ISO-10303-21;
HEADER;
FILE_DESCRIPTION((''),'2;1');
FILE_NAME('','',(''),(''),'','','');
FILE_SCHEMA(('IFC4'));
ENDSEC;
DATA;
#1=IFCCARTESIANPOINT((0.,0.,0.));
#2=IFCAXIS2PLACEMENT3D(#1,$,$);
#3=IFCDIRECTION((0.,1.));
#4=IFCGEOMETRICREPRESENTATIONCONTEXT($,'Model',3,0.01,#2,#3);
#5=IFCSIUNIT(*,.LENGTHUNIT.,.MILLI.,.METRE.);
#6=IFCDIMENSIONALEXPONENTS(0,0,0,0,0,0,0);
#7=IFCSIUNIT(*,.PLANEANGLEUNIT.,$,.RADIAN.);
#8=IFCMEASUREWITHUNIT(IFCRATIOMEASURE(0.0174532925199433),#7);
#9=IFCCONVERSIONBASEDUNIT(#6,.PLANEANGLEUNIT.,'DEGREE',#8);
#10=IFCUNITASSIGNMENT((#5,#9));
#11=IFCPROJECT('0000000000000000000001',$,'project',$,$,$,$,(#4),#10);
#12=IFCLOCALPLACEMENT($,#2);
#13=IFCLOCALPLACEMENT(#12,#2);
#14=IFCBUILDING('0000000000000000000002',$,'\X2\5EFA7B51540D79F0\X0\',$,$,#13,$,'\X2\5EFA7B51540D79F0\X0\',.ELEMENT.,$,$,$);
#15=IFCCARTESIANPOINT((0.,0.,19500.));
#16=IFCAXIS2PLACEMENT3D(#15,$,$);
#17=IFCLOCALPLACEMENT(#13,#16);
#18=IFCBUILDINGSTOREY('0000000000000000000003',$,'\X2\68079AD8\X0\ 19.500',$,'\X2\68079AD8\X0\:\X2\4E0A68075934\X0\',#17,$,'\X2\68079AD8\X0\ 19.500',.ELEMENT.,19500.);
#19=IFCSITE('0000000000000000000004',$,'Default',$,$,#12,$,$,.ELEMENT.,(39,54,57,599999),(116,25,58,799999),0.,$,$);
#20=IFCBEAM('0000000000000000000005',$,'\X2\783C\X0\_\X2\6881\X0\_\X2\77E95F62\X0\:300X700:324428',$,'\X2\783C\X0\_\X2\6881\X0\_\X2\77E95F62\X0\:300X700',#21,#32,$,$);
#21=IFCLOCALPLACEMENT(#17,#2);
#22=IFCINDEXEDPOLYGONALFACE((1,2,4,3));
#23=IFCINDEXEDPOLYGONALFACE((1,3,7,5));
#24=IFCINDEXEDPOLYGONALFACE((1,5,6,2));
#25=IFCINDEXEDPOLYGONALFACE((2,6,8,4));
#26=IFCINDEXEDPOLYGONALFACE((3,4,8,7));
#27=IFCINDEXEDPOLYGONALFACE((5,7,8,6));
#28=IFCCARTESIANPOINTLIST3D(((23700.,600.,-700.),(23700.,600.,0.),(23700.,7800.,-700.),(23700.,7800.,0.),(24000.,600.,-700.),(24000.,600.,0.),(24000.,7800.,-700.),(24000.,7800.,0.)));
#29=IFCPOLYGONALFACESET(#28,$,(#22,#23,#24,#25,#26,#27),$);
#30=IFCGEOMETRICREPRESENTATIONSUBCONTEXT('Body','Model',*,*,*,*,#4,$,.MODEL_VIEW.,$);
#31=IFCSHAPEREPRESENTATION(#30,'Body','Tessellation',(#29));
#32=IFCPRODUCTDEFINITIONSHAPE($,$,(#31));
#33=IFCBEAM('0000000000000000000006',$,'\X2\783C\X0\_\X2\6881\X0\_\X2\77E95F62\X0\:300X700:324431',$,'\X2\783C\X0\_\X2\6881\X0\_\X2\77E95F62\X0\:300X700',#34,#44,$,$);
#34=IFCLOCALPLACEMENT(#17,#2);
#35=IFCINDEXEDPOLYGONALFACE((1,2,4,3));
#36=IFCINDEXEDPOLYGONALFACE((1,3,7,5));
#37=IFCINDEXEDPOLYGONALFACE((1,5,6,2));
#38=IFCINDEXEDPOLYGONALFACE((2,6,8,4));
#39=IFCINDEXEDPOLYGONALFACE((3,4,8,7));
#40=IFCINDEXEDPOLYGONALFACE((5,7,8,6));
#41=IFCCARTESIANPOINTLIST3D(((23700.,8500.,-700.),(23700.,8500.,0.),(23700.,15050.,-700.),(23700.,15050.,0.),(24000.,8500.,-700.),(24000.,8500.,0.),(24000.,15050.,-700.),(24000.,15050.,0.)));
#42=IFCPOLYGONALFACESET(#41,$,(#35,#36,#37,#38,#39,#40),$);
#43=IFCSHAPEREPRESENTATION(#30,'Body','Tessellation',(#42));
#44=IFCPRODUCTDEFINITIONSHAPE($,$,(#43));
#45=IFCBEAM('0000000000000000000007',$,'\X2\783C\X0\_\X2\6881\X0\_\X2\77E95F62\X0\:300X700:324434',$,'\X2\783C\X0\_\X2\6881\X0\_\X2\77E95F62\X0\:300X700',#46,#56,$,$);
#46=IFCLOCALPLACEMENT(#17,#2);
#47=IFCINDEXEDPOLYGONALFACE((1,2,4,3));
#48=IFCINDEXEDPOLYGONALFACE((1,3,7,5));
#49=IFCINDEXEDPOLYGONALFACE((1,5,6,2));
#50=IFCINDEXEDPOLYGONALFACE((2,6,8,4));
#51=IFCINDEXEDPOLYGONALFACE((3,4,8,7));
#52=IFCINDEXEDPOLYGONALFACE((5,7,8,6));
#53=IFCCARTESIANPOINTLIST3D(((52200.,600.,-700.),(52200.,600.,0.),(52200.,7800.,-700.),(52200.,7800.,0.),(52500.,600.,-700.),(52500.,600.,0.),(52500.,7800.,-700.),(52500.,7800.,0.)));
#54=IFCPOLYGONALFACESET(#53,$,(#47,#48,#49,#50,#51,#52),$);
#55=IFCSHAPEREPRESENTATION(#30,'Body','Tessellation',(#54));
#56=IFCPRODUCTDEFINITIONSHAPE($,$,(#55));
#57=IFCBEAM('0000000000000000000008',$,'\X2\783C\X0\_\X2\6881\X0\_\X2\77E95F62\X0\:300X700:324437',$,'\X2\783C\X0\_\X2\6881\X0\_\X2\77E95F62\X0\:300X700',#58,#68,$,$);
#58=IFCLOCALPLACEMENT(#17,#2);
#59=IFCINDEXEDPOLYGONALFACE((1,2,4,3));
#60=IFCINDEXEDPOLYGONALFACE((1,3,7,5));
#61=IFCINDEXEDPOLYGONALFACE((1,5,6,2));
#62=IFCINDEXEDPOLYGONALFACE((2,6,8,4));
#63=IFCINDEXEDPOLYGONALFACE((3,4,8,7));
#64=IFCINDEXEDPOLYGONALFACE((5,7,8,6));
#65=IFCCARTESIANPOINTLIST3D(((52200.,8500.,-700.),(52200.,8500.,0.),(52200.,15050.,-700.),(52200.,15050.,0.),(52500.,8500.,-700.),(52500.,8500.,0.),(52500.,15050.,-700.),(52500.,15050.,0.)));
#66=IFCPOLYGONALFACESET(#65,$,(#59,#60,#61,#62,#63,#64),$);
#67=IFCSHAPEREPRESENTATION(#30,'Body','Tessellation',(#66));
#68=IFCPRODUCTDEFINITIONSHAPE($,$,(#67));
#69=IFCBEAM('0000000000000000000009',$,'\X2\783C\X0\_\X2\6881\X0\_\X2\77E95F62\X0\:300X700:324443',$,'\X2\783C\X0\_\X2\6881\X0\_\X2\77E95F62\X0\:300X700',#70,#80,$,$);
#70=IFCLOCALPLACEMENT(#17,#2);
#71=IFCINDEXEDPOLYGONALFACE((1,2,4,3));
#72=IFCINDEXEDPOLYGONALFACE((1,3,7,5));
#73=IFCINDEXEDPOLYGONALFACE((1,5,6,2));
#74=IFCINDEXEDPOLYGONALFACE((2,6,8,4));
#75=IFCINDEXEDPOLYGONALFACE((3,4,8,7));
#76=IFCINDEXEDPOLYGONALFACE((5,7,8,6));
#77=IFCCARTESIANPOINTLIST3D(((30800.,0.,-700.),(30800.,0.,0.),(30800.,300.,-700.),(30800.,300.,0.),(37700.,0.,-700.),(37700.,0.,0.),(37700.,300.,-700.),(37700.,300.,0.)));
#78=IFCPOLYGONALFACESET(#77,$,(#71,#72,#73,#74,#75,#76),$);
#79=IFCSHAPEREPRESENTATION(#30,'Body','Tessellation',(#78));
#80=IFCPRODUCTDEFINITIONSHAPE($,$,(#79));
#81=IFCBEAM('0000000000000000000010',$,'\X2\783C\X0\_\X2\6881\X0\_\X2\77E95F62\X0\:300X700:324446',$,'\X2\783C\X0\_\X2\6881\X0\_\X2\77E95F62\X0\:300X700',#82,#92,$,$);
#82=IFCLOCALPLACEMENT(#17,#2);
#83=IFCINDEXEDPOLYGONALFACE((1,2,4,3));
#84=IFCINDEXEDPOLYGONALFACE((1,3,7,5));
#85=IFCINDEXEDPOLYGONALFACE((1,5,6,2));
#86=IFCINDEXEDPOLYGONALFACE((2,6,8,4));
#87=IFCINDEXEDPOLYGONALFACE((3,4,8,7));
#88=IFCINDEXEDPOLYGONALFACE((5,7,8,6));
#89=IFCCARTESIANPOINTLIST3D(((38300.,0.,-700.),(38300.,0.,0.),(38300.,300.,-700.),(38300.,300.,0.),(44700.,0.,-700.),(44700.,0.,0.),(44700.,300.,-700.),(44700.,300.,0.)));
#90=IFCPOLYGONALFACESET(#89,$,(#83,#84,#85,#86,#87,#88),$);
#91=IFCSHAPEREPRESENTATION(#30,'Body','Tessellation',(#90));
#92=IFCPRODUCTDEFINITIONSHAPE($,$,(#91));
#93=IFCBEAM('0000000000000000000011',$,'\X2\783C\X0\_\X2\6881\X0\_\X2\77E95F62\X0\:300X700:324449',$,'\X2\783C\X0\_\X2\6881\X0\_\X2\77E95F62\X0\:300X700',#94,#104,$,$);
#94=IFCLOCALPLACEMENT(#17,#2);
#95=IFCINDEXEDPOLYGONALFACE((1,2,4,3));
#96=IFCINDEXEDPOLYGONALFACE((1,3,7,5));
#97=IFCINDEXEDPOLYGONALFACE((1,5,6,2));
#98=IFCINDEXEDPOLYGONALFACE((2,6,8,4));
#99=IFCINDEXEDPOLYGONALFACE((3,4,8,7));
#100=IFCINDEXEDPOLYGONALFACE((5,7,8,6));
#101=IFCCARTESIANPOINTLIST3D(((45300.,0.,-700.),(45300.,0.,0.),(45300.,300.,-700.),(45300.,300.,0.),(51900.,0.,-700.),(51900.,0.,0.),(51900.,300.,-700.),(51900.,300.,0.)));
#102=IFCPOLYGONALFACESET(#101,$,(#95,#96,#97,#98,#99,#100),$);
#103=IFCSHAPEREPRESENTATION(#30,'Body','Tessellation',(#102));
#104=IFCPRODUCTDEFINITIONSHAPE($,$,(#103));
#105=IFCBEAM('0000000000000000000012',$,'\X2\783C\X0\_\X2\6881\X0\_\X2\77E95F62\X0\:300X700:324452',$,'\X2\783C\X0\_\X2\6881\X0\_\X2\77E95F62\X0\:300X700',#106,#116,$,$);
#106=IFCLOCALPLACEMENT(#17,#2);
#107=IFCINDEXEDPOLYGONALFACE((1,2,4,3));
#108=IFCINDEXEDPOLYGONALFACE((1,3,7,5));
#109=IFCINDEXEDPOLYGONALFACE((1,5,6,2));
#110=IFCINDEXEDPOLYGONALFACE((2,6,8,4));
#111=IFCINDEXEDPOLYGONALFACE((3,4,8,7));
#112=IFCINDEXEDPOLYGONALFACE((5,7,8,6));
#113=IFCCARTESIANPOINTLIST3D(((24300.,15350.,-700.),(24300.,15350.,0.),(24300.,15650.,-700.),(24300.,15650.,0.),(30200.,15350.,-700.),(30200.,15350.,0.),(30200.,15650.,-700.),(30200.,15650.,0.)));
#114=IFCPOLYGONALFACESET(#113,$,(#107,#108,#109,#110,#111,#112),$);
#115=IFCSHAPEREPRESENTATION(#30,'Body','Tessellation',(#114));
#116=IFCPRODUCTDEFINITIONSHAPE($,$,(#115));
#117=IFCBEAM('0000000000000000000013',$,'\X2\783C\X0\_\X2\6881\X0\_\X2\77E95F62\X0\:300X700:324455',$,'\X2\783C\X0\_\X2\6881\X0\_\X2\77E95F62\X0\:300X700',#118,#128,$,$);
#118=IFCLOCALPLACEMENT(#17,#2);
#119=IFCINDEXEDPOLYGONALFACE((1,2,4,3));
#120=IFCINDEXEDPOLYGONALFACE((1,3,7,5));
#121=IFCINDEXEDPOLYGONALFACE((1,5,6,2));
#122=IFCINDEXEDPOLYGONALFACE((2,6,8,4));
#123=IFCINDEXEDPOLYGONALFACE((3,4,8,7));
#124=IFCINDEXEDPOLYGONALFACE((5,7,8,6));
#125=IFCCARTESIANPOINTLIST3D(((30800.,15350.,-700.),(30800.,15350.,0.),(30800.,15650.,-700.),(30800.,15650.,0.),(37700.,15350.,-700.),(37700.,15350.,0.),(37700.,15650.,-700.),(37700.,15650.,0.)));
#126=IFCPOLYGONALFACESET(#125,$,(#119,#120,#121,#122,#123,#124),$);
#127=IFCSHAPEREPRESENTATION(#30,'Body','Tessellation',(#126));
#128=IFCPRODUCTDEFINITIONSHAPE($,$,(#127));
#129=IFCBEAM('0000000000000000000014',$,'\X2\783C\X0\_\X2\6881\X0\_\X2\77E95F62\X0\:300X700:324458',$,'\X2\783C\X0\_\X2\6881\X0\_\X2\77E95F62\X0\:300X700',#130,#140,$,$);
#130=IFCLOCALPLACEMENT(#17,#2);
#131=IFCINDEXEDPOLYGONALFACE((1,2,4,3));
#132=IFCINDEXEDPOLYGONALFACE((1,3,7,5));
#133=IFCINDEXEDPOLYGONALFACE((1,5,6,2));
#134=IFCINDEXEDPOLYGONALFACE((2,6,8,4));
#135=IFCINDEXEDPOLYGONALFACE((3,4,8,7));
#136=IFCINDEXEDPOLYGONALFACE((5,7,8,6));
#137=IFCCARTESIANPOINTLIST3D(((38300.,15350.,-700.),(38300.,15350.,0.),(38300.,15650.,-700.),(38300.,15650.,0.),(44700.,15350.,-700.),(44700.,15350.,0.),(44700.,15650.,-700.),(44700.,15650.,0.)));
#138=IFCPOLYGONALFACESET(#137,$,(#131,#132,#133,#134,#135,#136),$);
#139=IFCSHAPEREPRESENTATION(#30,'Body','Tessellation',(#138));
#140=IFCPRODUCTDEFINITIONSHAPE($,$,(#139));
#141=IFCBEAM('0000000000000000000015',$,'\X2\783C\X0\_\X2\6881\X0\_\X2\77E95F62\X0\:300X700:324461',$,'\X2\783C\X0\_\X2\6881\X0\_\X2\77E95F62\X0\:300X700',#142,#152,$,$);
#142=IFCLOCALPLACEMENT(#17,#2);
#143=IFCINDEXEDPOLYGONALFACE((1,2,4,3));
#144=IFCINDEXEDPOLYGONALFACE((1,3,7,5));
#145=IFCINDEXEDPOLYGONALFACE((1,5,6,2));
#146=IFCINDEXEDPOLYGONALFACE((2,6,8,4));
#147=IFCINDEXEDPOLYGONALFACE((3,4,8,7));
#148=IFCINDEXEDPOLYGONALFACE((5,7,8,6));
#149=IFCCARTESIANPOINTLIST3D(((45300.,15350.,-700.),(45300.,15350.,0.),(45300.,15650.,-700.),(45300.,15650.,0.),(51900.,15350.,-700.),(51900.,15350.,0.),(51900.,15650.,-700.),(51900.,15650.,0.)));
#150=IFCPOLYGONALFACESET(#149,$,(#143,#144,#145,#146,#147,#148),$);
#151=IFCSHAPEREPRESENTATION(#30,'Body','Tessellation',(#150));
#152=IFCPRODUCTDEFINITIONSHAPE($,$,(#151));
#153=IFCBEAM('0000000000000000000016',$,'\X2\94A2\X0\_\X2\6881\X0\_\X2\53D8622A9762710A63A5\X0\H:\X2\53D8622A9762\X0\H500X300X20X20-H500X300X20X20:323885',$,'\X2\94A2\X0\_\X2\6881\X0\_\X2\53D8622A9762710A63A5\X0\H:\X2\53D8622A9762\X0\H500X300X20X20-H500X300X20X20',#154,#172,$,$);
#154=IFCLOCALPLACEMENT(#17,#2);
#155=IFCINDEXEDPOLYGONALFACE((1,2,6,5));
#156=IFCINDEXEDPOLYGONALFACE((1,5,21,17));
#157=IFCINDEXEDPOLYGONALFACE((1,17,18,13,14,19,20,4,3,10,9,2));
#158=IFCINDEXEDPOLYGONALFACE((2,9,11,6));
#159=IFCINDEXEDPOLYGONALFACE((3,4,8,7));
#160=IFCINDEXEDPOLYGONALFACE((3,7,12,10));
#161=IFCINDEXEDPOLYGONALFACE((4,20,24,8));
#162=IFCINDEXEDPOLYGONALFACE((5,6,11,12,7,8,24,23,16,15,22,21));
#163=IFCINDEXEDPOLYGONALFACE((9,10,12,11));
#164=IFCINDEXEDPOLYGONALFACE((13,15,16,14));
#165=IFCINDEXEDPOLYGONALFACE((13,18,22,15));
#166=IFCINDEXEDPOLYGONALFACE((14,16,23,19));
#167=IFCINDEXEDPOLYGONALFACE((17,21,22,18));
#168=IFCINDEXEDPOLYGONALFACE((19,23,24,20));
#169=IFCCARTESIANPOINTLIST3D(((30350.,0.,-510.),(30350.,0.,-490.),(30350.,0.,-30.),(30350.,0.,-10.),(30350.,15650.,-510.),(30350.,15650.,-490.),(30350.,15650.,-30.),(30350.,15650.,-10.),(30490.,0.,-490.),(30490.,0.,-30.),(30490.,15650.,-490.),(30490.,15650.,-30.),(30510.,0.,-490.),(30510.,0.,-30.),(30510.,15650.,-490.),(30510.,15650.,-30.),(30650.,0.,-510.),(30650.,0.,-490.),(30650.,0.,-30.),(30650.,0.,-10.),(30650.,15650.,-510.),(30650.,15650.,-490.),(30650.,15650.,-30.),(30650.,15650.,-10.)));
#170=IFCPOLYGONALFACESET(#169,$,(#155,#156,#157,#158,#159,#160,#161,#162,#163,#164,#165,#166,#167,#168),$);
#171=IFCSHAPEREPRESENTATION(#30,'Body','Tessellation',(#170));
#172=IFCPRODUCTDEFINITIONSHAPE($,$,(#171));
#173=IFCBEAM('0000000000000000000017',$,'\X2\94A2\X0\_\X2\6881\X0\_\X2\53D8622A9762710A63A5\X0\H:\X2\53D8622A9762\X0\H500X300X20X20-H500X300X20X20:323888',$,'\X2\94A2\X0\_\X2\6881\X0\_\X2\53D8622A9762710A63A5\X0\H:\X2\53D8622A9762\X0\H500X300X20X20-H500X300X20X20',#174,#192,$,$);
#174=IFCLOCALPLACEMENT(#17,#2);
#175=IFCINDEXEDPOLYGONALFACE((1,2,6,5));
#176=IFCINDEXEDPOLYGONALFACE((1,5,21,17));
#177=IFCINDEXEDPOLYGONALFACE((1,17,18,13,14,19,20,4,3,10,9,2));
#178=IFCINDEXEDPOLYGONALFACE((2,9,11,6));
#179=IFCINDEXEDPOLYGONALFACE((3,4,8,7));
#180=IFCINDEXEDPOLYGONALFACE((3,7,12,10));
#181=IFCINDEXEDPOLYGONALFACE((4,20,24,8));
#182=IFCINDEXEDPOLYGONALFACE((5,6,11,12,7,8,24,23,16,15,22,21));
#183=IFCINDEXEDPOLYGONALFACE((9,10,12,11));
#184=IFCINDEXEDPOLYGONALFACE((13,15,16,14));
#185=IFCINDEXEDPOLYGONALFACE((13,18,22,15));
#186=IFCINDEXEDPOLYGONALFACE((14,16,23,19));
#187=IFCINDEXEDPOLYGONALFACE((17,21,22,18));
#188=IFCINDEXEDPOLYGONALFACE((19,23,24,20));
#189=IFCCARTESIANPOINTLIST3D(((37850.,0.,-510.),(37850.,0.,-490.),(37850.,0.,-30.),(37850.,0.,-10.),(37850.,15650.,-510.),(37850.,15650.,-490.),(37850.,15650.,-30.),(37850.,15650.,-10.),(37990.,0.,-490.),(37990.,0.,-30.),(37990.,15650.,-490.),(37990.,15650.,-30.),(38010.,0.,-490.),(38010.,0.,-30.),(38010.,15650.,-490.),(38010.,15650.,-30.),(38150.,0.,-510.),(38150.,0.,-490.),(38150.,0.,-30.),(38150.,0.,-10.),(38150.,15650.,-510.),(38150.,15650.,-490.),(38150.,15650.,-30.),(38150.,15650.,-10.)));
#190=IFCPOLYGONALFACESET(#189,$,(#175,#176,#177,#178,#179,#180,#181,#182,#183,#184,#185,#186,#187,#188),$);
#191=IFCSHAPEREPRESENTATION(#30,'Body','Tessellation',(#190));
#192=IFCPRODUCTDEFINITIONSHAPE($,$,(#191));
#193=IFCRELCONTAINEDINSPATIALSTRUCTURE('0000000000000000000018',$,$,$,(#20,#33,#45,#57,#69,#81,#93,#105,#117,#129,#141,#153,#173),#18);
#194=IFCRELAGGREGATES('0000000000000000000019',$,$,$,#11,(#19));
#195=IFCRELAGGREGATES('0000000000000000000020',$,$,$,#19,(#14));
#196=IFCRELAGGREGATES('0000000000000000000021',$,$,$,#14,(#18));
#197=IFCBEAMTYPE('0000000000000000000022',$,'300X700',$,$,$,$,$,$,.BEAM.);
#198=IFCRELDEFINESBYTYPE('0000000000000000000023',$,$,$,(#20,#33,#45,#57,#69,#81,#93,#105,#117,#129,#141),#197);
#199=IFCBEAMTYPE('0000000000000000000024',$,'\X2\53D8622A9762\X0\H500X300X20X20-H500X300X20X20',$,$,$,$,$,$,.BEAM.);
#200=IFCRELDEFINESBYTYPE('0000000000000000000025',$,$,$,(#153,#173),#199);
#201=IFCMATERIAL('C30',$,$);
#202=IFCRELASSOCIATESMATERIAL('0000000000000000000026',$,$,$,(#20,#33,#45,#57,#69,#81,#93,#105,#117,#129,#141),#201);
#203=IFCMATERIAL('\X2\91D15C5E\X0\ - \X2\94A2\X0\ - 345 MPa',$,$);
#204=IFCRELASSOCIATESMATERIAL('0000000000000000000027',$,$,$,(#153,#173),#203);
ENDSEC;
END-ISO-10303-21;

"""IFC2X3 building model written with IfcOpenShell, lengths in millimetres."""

from ifc_helpers import new_model, entity, si_unit, converted_unit, direction, frame, frame_2d, origin, place, context, subcontext, project, spatial, rectangle, i_section, extrude, material, type_object, element, save


model = new_model("IFC2X3")

# Units and contexts
model_context = context("Model", 3, precision=0.01, world=origin(), true_north=direction((0.0, 1.0)))
body_context = subcontext(model_context, "Body", "Model", "MODEL_VIEW")
ifc_project = project(units=[si_unit("LENGTHUNIT", "METRE", prefix="MILLI"), converted_unit("PLANEANGLEUNIT", "DEGREE", entity("IfcRatioMeasure", 0.0174532925199433), si_unit("PLANEANGLEUNIT", "RADIAN"), dimensions=[0, 0, 0, 0, 0, 0, 0])], contexts=[model_context])

# Site, building, storey
site_placement = place(None, origin())
site = spatial("IfcSite", under=ifc_project, at=site_placement, Name="Default", CompositionType="ELEMENT", RefLatitude=(39, 54, 57, 599999), RefLongitude=(116, 25, 58, 799999), RefElevation=0.0)
building_placement = place(site_placement, origin())
building = spatial("IfcBuilding", under=site, at=building_placement, Name="建筑名称", LongName="建筑名称", CompositionType="ELEMENT")
storey_placement = place(building_placement, frame((0.0, 0.0, 19500.0)))
storey = spatial("IfcBuildingStorey", under=building, at=storey_placement, Name="标高 19.500", ObjectType="标高:上标头", LongName="标高 19.500", CompositionType="ELEMENT", Elevation=19500.0)

# Beams
ifc_material_1 = material(Name="C30")
beam_type_1 = type_object("IfcBeamType", Name="300X700", PredefinedType="BEAM")
beam_1_placement = place(storey_placement, frame((24000.0, 150.0, 0.0), z_axis=(0.0, 0.0, 1.0), x_axis=(0.0, 1.0, 0.0)))
element("IfcBeam", 1, at=beam_1_placement, inside=storey, type_object=beam_type_1, material=ifc_material_1, Name="砼_梁_矩形:300X700:324428", ObjectType="砼_梁_矩形:300X700", context=body_context, shape_type="SweptSolid", body=[
    extrude(rectangle(XDim=700.0, YDim=300.0, at=frame_2d((0.0, 0.0), x_axis=(1.0, 0.0))), frame((450.0, 150.0, -350.0), z_axis=(1.0, 0.0, 0.0), x_axis=(0.0, 0.0, -1.0)), (0.0, 0.0, 1.0), 7200.0),
])
beam_2_placement = place(storey_placement, frame((24000.0, 8150.0, 0.0), z_axis=(0.0, 0.0, 1.0), x_axis=(0.0, 1.0, 0.0)))
element("IfcBeam", 2, at=beam_2_placement, inside=storey, type_object=beam_type_1, material=ifc_material_1, Name="砼_梁_矩形:300X700:324431", ObjectType="砼_梁_矩形:300X700", context=body_context, shape_type="SweptSolid", body=[
    extrude(rectangle(XDim=700.0, YDim=300.0, at=frame_2d((0.0, 0.0), x_axis=(1.0, 0.0))), frame((350.0, 150.0, -350.0), z_axis=(1.0, 0.0, 0.0), x_axis=(0.0, 0.0, -1.0)), (0.0, 0.0, 1.0), 6550.0),
])
beam_3_placement = place(storey_placement, frame((52500.0, 0.0, 0.0), z_axis=(0.0, 0.0, 1.0), x_axis=(0.0, 1.0, 0.0)))
element("IfcBeam", 3, at=beam_3_placement, inside=storey, type_object=beam_type_1, material=ifc_material_1, Name="砼_梁_矩形:300X700:324434", ObjectType="砼_梁_矩形:300X700", context=body_context, shape_type="SweptSolid", body=[
    extrude(rectangle(XDim=700.0, YDim=300.0, at=frame_2d((0.0, 0.0), x_axis=(1.0, 0.0))), frame((600.0, 150.0, -350.0), z_axis=(1.0, 0.0, 0.0), x_axis=(0.0, 0.0, -1.0)), (0.0, 0.0, 1.0), 7200.0),
])
beam_4_placement = place(storey_placement, frame((52500.0, 8150.0, 0.0), z_axis=(0.0, 0.0, 1.0), x_axis=(0.0, 1.0, 0.0)))
element("IfcBeam", 4, at=beam_4_placement, inside=storey, type_object=beam_type_1, material=ifc_material_1, Name="砼_梁_矩形:300X700:324437", ObjectType="砼_梁_矩形:300X700", context=body_context, shape_type="SweptSolid", body=[
    extrude(rectangle(XDim=700.0, YDim=300.0, at=frame_2d((0.0, 0.0), x_axis=(1.0, 0.0))), frame((350.0, 150.0, -350.0), z_axis=(1.0, 0.0, 0.0), x_axis=(0.0, 0.0, -1.0)), (0.0, 0.0, 1.0), 6550.0),
])
beam_5_placement = place(storey_placement, frame((30500.0, 0.0, 0.0)))
element("IfcBeam", 5, at=beam_5_placement, inside=storey, type_object=beam_type_1, material=ifc_material_1, Name="砼_梁_矩形:300X700:324443", ObjectType="砼_梁_矩形:300X700", context=body_context, shape_type="SweptSolid", body=[
    extrude(rectangle(XDim=700.0, YDim=300.0, at=frame_2d((0.0, 0.0), x_axis=(1.0, 0.0))), frame((300.0, 150.0, -350.0), z_axis=(1.0, 0.0, 0.0), x_axis=(0.0, 0.0, -1.0)), (0.0, 0.0, 1.0), 6900.0),
])
beam_6_placement = place(storey_placement, frame((38000.0, 0.0, 0.0)))
element("IfcBeam", 6, at=beam_6_placement, inside=storey, type_object=beam_type_1, material=ifc_material_1, Name="砼_梁_矩形:300X700:324446", ObjectType="砼_梁_矩形:300X700", context=body_context, shape_type="SweptSolid", body=[
    extrude(rectangle(XDim=700.0, YDim=300.0, at=frame_2d((0.0, 0.0), x_axis=(1.0, 0.0))), frame((300.0, 150.0, -350.0), z_axis=(1.0, 0.0, 0.0), x_axis=(0.0, 0.0, -1.0)), (0.0, 0.0, 1.0), 6400.0),
])
beam_7_placement = place(storey_placement, frame((45000.0, 0.0, 0.0)))
element("IfcBeam", 7, at=beam_7_placement, inside=storey, type_object=beam_type_1, material=ifc_material_1, Name="砼_梁_矩形:300X700:324449", ObjectType="砼_梁_矩形:300X700", context=body_context, shape_type="SweptSolid", body=[
    extrude(rectangle(XDim=700.0, YDim=300.0, at=frame_2d((0.0, 0.0), x_axis=(1.0, 0.0))), frame((300.0, 150.0, -350.0), z_axis=(1.0, 0.0, 0.0), x_axis=(0.0, 0.0, -1.0)), (0.0, 0.0, 1.0), 6600.0),
])
beam_8_placement = place(storey_placement, frame((23850.0, 15650.0, 0.0)))
element("IfcBeam", 8, at=beam_8_placement, inside=storey, type_object=beam_type_1, material=ifc_material_1, Name="砼_梁_矩形:300X700:324452", ObjectType="砼_梁_矩形:300X700", context=body_context, shape_type="SweptSolid", body=[
    extrude(rectangle(XDim=700.0, YDim=300.0, at=frame_2d((0.0, 0.0), x_axis=(1.0, 0.0))), frame((450.0, -150.0, -350.0), z_axis=(1.0, 0.0, 0.0), x_axis=(0.0, 0.0, -1.0)), (0.0, 0.0, 1.0), 5900.0),
])
beam_9_placement = place(storey_placement, frame((30500.0, 15650.0, 0.0)))
element("IfcBeam", 9, at=beam_9_placement, inside=storey, type_object=beam_type_1, material=ifc_material_1, Name="砼_梁_矩形:300X700:324455", ObjectType="砼_梁_矩形:300X700", context=body_context, shape_type="SweptSolid", body=[
    extrude(rectangle(XDim=700.0, YDim=300.0, at=frame_2d((0.0, 0.0), x_axis=(1.0, 0.0))), frame((300.0, -150.0, -350.0), z_axis=(1.0, 0.0, 0.0), x_axis=(0.0, 0.0, -1.0)), (0.0, 0.0, 1.0), 6900.0),
])
beam_10_placement = place(storey_placement, frame((38000.0, 15650.0, 0.0)))
element("IfcBeam", 10, at=beam_10_placement, inside=storey, type_object=beam_type_1, material=ifc_material_1, Name="砼_梁_矩形:300X700:324458", ObjectType="砼_梁_矩形:300X700", context=body_context, shape_type="SweptSolid", body=[
    extrude(rectangle(XDim=700.0, YDim=300.0, at=frame_2d((0.0, 0.0), x_axis=(1.0, 0.0))), frame((300.0, -150.0, -350.0), z_axis=(1.0, 0.0, 0.0), x_axis=(0.0, 0.0, -1.0)), (0.0, 0.0, 1.0), 6400.0),
])
beam_11_placement = place(storey_placement, frame((45000.0, 15650.0, 0.0)))
element("IfcBeam", 11, at=beam_11_placement, inside=storey, type_object=beam_type_1, material=ifc_material_1, Name="砼_梁_矩形:300X700:324461", ObjectType="砼_梁_矩形:300X700", context=body_context, shape_type="SweptSolid", body=[
    extrude(rectangle(XDim=700.0, YDim=300.0, at=frame_2d((0.0, 0.0), x_axis=(1.0, 0.0))), frame((300.0, -150.0, -350.0), z_axis=(1.0, 0.0, 0.0), x_axis=(0.0, 0.0, -1.0)), (0.0, 0.0, 1.0), 6600.0),
])
ifc_material_2 = material(Name="金属 - 钢 - 345 MPa")
beam_type_2 = type_object("IfcBeamType", Name="变截面H500X300X20X20-H500X300X20X20", PredefinedType="BEAM")
for number, where, z_axis, x_axis, name in (
    (12, (30500.0, 0.0, 0.0), (0.0, 0.0, 1.0), (0.0, 1.0, 0.0), "钢_梁_变截面焊接H:变截面H500X300X20X20-H500X300X20X20:323885"),
    (13, (38000.0, 0.0, 0.0), (0.0, 0.0, 1.0), (0.0, 1.0, 0.0), "钢_梁_变截面焊接H:变截面H500X300X20X20-H500X300X20X20:323888"),
):
    element("IfcBeam", number, at=place(storey_placement, frame(where, z_axis=z_axis, x_axis=x_axis)), inside=storey, type_object=beam_type_2, material=ifc_material_2, Name=name, ObjectType="钢_梁_变截面焊接H:变截面H500X300X20X20-H500X300X20X20", context=body_context, shape_type="SweptSolid", body=[
        extrude(i_section(OverallWidth=300.0, OverallDepth=500.0, WebThickness=20.0, FlangeThickness=20.0, at=frame_2d((0.0, 0.0), x_axis=(0.0, 1.0))), frame((0.0, 0.0, -260.0), z_axis=(1.0, 0.0, 0.0), x_axis=(0.0, 0.0, -1.0)), (0.0, 0.0, 1.0), 15650.0),
    ])

save(model, "model.ifc")
